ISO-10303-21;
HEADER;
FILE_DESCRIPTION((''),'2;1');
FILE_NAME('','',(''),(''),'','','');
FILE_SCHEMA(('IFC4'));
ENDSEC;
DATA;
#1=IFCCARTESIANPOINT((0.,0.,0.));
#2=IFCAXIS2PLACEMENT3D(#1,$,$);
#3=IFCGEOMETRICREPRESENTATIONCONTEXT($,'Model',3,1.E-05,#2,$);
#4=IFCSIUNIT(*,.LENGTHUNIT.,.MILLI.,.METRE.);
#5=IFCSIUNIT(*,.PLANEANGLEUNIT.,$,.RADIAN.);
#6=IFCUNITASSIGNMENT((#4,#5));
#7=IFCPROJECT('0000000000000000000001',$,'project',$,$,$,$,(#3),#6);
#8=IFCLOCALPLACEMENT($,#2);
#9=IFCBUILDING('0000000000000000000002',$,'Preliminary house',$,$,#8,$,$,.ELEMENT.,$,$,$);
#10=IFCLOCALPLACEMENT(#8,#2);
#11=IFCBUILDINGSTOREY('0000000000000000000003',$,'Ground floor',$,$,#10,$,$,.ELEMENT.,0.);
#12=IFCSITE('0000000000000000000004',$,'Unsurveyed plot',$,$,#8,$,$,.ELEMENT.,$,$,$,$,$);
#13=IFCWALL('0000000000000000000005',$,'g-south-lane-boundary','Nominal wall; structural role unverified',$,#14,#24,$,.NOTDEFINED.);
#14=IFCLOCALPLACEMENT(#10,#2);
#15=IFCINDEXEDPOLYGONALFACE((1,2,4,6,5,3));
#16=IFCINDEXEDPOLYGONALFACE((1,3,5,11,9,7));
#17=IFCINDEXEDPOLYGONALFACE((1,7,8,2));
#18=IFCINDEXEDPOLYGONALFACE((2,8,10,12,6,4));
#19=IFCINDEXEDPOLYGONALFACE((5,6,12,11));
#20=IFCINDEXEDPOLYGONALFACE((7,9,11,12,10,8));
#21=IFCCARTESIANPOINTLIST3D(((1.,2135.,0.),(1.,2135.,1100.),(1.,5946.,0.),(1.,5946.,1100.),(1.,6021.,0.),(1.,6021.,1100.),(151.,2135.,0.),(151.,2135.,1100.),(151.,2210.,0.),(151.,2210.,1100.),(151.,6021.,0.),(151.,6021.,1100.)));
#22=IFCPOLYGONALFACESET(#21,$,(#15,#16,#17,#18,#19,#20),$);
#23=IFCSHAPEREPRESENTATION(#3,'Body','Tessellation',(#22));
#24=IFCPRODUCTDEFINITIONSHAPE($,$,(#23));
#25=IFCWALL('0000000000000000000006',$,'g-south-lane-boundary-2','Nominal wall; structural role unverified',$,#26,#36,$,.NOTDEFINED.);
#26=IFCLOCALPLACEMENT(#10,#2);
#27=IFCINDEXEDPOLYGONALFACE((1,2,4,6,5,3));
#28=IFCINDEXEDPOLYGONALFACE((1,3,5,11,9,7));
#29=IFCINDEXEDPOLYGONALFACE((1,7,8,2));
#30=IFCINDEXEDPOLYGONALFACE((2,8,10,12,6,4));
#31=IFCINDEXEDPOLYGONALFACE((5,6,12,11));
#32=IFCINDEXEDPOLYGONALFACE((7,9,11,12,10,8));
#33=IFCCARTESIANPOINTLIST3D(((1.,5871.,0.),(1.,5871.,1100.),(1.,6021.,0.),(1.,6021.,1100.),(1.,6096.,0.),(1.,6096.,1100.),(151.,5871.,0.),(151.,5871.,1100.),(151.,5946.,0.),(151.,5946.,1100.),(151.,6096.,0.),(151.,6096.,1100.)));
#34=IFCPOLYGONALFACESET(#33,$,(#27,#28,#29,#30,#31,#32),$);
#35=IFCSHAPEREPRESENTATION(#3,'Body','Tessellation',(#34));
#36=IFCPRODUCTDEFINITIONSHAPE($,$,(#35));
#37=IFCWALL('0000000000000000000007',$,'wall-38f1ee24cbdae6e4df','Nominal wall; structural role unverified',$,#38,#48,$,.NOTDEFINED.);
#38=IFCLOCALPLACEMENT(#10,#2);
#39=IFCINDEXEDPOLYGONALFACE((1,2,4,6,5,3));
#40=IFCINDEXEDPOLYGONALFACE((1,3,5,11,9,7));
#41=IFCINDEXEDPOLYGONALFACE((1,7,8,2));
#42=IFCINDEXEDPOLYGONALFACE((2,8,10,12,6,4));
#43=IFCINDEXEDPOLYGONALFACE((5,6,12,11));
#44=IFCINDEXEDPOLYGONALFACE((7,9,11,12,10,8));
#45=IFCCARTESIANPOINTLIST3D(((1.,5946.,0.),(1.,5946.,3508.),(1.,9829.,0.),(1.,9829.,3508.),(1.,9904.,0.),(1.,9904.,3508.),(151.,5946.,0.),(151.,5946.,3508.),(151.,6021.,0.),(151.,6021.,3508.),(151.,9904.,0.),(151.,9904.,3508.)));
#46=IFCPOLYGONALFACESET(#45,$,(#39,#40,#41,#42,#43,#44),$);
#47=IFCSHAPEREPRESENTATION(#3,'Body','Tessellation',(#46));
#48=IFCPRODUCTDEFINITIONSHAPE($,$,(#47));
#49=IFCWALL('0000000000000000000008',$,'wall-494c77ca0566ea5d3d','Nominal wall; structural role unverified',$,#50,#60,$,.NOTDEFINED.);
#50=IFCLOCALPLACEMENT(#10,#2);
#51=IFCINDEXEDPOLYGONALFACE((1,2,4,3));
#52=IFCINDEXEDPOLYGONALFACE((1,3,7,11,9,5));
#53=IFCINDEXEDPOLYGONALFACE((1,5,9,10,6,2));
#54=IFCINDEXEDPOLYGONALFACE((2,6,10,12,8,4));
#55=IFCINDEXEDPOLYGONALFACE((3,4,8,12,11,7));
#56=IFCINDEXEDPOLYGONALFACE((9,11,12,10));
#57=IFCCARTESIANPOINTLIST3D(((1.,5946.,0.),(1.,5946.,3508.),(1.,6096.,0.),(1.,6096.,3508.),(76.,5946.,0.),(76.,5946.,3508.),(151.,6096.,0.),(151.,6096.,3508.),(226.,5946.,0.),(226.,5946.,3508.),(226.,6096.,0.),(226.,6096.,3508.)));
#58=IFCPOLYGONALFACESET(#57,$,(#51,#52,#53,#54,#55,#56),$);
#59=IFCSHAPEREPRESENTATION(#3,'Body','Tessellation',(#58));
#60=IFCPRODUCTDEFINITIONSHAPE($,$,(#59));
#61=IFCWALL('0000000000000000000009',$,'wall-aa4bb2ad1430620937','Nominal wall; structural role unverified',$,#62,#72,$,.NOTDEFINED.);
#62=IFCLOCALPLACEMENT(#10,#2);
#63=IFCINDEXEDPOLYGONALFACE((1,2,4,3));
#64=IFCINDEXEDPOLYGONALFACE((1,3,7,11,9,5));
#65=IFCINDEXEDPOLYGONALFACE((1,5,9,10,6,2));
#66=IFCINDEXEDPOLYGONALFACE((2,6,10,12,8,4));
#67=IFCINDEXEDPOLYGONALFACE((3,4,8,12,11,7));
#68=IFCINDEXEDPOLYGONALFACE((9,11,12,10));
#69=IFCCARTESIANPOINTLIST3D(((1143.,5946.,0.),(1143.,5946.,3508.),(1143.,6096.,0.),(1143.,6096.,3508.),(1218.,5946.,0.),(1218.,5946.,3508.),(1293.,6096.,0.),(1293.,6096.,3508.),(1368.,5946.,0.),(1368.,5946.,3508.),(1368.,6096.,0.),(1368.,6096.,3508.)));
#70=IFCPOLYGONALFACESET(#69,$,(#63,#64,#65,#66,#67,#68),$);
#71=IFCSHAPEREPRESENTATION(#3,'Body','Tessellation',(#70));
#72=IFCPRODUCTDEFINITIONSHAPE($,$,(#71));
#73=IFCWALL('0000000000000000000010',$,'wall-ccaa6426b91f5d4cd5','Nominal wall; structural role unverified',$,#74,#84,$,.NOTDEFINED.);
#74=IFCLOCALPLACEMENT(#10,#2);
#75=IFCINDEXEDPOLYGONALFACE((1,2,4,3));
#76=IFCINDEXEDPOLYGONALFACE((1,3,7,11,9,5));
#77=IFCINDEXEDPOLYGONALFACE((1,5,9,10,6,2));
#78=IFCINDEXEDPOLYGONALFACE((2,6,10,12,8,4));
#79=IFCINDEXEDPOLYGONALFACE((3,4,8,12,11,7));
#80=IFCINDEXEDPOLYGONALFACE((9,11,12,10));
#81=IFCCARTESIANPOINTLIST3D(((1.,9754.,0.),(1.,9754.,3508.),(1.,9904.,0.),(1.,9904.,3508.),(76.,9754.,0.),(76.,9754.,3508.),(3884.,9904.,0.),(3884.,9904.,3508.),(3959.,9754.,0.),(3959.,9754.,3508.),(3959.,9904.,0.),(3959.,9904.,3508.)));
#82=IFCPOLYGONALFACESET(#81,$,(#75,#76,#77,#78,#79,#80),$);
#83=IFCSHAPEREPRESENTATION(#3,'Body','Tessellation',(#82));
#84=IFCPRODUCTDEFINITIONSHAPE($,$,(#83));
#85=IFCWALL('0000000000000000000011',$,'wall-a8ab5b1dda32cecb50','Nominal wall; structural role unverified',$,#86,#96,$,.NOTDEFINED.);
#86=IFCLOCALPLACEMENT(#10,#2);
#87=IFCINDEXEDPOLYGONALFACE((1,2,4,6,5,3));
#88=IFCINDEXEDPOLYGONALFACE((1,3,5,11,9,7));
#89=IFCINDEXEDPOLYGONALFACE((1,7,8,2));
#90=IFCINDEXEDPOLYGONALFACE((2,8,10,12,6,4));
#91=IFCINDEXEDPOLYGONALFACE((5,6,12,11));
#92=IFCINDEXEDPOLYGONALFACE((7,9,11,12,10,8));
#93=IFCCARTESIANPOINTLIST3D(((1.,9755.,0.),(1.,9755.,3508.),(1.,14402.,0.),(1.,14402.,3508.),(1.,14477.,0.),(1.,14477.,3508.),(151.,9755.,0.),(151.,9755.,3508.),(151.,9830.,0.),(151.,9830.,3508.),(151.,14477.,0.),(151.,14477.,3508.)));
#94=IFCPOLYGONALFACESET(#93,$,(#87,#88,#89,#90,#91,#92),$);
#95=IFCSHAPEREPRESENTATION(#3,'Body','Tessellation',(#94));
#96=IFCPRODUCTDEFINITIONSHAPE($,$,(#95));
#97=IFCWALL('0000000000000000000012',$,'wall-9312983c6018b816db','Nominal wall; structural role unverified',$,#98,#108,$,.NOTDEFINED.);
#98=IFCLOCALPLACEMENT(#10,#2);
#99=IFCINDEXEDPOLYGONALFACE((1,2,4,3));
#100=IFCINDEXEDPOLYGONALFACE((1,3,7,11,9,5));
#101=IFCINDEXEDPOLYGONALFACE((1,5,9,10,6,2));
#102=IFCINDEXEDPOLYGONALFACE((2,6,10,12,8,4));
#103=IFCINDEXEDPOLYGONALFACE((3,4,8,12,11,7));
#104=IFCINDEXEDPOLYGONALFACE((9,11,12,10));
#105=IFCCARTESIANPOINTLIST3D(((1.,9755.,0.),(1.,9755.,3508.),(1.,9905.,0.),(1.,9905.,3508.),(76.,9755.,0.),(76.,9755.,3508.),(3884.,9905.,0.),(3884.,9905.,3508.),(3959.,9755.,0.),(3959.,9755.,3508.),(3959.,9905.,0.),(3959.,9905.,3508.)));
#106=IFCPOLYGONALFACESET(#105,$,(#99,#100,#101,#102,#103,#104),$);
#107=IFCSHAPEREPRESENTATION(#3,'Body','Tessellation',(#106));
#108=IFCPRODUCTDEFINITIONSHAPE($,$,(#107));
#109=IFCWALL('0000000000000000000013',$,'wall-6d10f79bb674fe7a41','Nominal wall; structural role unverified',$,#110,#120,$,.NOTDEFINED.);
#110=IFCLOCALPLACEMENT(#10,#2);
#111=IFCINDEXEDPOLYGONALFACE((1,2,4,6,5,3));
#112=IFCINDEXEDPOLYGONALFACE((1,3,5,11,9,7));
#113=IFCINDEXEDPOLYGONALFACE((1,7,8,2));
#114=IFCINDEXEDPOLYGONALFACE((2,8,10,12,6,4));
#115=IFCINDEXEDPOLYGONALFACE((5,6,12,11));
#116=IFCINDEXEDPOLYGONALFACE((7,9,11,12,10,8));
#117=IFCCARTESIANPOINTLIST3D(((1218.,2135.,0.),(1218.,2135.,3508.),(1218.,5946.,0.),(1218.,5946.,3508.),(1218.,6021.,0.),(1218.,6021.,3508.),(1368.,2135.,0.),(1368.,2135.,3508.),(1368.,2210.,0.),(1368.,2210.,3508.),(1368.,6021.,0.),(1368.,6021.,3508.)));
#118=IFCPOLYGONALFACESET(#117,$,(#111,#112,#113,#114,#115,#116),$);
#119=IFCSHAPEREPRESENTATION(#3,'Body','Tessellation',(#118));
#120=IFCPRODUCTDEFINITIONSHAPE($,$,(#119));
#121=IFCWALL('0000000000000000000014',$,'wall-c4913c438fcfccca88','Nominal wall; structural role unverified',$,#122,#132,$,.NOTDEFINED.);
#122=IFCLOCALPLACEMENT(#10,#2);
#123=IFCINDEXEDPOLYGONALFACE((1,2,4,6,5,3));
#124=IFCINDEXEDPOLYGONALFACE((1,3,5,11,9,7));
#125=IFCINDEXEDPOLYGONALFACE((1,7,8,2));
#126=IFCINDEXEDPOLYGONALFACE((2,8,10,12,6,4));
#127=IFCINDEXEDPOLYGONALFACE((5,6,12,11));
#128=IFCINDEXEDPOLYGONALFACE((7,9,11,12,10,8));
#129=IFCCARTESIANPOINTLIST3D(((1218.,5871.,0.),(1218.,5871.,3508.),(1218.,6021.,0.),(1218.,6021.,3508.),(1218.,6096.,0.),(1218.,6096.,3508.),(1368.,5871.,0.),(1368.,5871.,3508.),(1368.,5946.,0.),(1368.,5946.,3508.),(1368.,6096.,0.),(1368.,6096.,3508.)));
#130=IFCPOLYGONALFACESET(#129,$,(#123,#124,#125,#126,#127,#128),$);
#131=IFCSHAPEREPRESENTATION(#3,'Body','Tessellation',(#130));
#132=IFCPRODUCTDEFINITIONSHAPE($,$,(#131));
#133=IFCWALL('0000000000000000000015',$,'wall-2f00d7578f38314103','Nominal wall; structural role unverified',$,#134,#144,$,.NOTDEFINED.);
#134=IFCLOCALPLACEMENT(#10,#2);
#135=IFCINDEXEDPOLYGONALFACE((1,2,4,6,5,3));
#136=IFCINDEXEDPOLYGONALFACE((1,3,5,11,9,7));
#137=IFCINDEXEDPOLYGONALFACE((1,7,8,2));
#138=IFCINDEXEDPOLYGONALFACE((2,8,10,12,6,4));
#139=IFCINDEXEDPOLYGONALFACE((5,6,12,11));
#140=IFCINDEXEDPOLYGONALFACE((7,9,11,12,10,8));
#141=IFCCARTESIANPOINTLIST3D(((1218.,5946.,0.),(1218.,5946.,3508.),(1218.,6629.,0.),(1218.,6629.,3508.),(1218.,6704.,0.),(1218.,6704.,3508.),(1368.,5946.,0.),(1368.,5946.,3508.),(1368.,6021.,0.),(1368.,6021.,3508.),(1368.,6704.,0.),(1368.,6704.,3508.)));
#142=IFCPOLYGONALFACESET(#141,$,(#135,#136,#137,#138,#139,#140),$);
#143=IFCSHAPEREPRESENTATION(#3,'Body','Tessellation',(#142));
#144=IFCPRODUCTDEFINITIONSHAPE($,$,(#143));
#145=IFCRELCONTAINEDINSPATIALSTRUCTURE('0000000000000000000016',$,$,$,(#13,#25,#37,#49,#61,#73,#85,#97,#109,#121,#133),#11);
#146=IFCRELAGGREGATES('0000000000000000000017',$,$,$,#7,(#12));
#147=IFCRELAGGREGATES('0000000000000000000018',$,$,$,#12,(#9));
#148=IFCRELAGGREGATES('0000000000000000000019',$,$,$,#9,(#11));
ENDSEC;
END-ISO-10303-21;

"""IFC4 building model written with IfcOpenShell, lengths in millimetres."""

from ifc_helpers import new_model, si_unit, origin, place, context, project, spatial, polyline, outline, extrude, element, save


model = new_model("IFC4")

# Units and contexts
model_context = context("Model", 3, precision=1e-05, world=origin())
ifc_project = project(units=[si_unit("LENGTHUNIT", "METRE", prefix="MILLI"), si_unit("PLANEANGLEUNIT", "RADIAN")], contexts=[model_context])

# Site, building, storey
placement_1 = place(None, origin())
site = spatial("IfcSite", under=ifc_project, at=placement_1, Name="Unsurveyed plot", CompositionType="ELEMENT")
building = spatial("IfcBuilding", under=site, at=placement_1, Name="Preliminary house", CompositionType="ELEMENT")
placement_2 = place(placement_1, origin())
storey = spatial("IfcBuildingStorey", under=building, at=placement_2, Name="Ground floor", CompositionType="ELEMENT", Elevation=0.0)

# Walls
element("IfcWall", 1, at=placement_2, inside=storey, Name="g-south-lane-boundary", Description="Nominal wall; structural role unverified", PredefinedType="NOTDEFINED", context=model_context, shape_type="SweptSolid", body=[
    extrude(outline(polyline([(1.0, 5946.0), (1.0, 6021.0), (151.0, 6021.0), (151.0, 2210.0), (151.0, 2135.0), (1.0, 2135.0), (1.0, 5946.0)])), origin(), (0.0, 0.0, 1.0), 1100.0),
])
element("IfcWall", 2, at=placement_2, inside=storey, Name="g-south-lane-boundary-2", Description="Nominal wall; structural role unverified", PredefinedType="NOTDEFINED", context=model_context, shape_type="SweptSolid", body=[
    extrude(outline(polyline([(1.0, 6021.0), (1.0, 6096.0), (151.0, 6096.0), (151.0, 5946.0), (151.0, 5871.0), (1.0, 5871.0), (1.0, 6021.0)])), origin(), (0.0, 0.0, 1.0), 1100.0),
])
element("IfcWall", 3, at=placement_2, inside=storey, Name="wall-38f1ee24cbdae6e4df", Description="Nominal wall; structural role unverified", PredefinedType="NOTDEFINED", context=model_context, shape_type="SweptSolid", body=[
    extrude(outline(polyline([(1.0, 9829.0), (1.0, 9904.0), (151.0, 9904.0), (151.0, 6021.0), (151.0, 5946.0), (1.0, 5946.0), (1.0, 9829.0)])), origin(), (0.0, 0.0, 1.0), 3508.0),
])
element("IfcWall", 4, at=placement_2, inside=storey, Name="wall-494c77ca0566ea5d3d", Description="Nominal wall; structural role unverified", PredefinedType="NOTDEFINED", context=model_context, shape_type="SweptSolid", body=[
    extrude(outline(polyline([(151.0, 6096.0), (226.0, 6096.0), (226.0, 5946.0), (76.0, 5946.0), (1.0, 5946.0), (1.0, 6096.0), (151.0, 6096.0)])), origin(), (0.0, 0.0, 1.0), 3508.0),
])

# Walls
element("IfcWall", 5, at=placement_2, inside=storey, Name="wall-aa4bb2ad1430620937", Description="Nominal wall; structural role unverified", PredefinedType="NOTDEFINED", context=model_context, shape_type="SweptSolid", body=[
    extrude(outline(polyline([(1293.0, 6096.0), (1368.0, 6096.0), (1368.0, 5946.0), (1218.0, 5946.0), (1143.0, 5946.0), (1143.0, 6096.0), (1293.0, 6096.0)])), origin(), (0.0, 0.0, 1.0), 3508.0),
])
element("IfcWall", 6, at=placement_2, inside=storey, Name="wall-ccaa6426b91f5d4cd5", Description="Nominal wall; structural role unverified", PredefinedType="NOTDEFINED", context=model_context, shape_type="SweptSolid", body=[
    extrude(outline(polyline([(3884.0, 9904.0), (3959.0, 9904.0), (3959.0, 9754.0), (76.0, 9754.0), (1.0, 9754.0), (1.0, 9904.0), (3884.0, 9904.0)])), origin(), (0.0, 0.0, 1.0), 3508.0),
])
element("IfcWall", 7, at=placement_2, inside=storey, Name="wall-a8ab5b1dda32cecb50", Description="Nominal wall; structural role unverified", PredefinedType="NOTDEFINED", context=model_context, shape_type="SweptSolid", body=[
    extrude(outline(polyline([(1.0, 14402.0), (1.0, 14477.0), (151.0, 14477.0), (151.0, 9830.0), (151.0, 9755.0), (1.0, 9755.0), (1.0, 14402.0)])), origin(), (0.0, 0.0, 1.0), 3508.0),
])
element("IfcWall", 8, at=placement_2, inside=storey, Name="wall-9312983c6018b816db", Description="Nominal wall; structural role unverified", PredefinedType="NOTDEFINED", context=model_context, shape_type="SweptSolid", body=[
    extrude(outline(polyline([(3884.0, 9905.0), (3959.0, 9905.0), (3959.0, 9755.0), (76.0, 9755.0), (1.0, 9755.0), (1.0, 9905.0), (3884.0, 9905.0)])), origin(), (0.0, 0.0, 1.0), 3508.0),
])

# Walls
element("IfcWall", 9, at=placement_2, inside=storey, Name="wall-6d10f79bb674fe7a41", Description="Nominal wall; structural role unverified", PredefinedType="NOTDEFINED", context=model_context, shape_type="SweptSolid", body=[
    extrude(outline(polyline([(1218.0, 5946.0), (1218.0, 6021.0), (1368.0, 6021.0), (1368.0, 2210.0), (1368.0, 2135.0), (1218.0, 2135.0), (1218.0, 5946.0)])), origin(), (0.0, 0.0, 1.0), 3508.0),
])
element("IfcWall", 10, at=placement_2, inside=storey, Name="wall-c4913c438fcfccca88", Description="Nominal wall; structural role unverified", PredefinedType="NOTDEFINED", context=model_context, shape_type="SweptSolid", body=[
    extrude(outline(polyline([(1218.0, 6021.0), (1218.0, 6096.0), (1368.0, 6096.0), (1368.0, 5946.0), (1368.0, 5871.0), (1218.0, 5871.0), (1218.0, 6021.0)])), origin(), (0.0, 0.0, 1.0), 3508.0),
])

# Wall
element("IfcWall", 11, at=placement_2, inside=storey, Name="wall-2f00d7578f38314103", Description="Nominal wall; structural role unverified", PredefinedType="NOTDEFINED", context=model_context, shape_type="SweptSolid", body=[
    extrude(outline(polyline([(1218.0, 6629.0), (1218.0, 6704.0), (1368.0, 6704.0), (1368.0, 6021.0), (1368.0, 5946.0), (1218.0, 5946.0), (1218.0, 6629.0)])), origin(), (0.0, 0.0, 1.0), 3508.0),
])

save(model, "model.ifc")
